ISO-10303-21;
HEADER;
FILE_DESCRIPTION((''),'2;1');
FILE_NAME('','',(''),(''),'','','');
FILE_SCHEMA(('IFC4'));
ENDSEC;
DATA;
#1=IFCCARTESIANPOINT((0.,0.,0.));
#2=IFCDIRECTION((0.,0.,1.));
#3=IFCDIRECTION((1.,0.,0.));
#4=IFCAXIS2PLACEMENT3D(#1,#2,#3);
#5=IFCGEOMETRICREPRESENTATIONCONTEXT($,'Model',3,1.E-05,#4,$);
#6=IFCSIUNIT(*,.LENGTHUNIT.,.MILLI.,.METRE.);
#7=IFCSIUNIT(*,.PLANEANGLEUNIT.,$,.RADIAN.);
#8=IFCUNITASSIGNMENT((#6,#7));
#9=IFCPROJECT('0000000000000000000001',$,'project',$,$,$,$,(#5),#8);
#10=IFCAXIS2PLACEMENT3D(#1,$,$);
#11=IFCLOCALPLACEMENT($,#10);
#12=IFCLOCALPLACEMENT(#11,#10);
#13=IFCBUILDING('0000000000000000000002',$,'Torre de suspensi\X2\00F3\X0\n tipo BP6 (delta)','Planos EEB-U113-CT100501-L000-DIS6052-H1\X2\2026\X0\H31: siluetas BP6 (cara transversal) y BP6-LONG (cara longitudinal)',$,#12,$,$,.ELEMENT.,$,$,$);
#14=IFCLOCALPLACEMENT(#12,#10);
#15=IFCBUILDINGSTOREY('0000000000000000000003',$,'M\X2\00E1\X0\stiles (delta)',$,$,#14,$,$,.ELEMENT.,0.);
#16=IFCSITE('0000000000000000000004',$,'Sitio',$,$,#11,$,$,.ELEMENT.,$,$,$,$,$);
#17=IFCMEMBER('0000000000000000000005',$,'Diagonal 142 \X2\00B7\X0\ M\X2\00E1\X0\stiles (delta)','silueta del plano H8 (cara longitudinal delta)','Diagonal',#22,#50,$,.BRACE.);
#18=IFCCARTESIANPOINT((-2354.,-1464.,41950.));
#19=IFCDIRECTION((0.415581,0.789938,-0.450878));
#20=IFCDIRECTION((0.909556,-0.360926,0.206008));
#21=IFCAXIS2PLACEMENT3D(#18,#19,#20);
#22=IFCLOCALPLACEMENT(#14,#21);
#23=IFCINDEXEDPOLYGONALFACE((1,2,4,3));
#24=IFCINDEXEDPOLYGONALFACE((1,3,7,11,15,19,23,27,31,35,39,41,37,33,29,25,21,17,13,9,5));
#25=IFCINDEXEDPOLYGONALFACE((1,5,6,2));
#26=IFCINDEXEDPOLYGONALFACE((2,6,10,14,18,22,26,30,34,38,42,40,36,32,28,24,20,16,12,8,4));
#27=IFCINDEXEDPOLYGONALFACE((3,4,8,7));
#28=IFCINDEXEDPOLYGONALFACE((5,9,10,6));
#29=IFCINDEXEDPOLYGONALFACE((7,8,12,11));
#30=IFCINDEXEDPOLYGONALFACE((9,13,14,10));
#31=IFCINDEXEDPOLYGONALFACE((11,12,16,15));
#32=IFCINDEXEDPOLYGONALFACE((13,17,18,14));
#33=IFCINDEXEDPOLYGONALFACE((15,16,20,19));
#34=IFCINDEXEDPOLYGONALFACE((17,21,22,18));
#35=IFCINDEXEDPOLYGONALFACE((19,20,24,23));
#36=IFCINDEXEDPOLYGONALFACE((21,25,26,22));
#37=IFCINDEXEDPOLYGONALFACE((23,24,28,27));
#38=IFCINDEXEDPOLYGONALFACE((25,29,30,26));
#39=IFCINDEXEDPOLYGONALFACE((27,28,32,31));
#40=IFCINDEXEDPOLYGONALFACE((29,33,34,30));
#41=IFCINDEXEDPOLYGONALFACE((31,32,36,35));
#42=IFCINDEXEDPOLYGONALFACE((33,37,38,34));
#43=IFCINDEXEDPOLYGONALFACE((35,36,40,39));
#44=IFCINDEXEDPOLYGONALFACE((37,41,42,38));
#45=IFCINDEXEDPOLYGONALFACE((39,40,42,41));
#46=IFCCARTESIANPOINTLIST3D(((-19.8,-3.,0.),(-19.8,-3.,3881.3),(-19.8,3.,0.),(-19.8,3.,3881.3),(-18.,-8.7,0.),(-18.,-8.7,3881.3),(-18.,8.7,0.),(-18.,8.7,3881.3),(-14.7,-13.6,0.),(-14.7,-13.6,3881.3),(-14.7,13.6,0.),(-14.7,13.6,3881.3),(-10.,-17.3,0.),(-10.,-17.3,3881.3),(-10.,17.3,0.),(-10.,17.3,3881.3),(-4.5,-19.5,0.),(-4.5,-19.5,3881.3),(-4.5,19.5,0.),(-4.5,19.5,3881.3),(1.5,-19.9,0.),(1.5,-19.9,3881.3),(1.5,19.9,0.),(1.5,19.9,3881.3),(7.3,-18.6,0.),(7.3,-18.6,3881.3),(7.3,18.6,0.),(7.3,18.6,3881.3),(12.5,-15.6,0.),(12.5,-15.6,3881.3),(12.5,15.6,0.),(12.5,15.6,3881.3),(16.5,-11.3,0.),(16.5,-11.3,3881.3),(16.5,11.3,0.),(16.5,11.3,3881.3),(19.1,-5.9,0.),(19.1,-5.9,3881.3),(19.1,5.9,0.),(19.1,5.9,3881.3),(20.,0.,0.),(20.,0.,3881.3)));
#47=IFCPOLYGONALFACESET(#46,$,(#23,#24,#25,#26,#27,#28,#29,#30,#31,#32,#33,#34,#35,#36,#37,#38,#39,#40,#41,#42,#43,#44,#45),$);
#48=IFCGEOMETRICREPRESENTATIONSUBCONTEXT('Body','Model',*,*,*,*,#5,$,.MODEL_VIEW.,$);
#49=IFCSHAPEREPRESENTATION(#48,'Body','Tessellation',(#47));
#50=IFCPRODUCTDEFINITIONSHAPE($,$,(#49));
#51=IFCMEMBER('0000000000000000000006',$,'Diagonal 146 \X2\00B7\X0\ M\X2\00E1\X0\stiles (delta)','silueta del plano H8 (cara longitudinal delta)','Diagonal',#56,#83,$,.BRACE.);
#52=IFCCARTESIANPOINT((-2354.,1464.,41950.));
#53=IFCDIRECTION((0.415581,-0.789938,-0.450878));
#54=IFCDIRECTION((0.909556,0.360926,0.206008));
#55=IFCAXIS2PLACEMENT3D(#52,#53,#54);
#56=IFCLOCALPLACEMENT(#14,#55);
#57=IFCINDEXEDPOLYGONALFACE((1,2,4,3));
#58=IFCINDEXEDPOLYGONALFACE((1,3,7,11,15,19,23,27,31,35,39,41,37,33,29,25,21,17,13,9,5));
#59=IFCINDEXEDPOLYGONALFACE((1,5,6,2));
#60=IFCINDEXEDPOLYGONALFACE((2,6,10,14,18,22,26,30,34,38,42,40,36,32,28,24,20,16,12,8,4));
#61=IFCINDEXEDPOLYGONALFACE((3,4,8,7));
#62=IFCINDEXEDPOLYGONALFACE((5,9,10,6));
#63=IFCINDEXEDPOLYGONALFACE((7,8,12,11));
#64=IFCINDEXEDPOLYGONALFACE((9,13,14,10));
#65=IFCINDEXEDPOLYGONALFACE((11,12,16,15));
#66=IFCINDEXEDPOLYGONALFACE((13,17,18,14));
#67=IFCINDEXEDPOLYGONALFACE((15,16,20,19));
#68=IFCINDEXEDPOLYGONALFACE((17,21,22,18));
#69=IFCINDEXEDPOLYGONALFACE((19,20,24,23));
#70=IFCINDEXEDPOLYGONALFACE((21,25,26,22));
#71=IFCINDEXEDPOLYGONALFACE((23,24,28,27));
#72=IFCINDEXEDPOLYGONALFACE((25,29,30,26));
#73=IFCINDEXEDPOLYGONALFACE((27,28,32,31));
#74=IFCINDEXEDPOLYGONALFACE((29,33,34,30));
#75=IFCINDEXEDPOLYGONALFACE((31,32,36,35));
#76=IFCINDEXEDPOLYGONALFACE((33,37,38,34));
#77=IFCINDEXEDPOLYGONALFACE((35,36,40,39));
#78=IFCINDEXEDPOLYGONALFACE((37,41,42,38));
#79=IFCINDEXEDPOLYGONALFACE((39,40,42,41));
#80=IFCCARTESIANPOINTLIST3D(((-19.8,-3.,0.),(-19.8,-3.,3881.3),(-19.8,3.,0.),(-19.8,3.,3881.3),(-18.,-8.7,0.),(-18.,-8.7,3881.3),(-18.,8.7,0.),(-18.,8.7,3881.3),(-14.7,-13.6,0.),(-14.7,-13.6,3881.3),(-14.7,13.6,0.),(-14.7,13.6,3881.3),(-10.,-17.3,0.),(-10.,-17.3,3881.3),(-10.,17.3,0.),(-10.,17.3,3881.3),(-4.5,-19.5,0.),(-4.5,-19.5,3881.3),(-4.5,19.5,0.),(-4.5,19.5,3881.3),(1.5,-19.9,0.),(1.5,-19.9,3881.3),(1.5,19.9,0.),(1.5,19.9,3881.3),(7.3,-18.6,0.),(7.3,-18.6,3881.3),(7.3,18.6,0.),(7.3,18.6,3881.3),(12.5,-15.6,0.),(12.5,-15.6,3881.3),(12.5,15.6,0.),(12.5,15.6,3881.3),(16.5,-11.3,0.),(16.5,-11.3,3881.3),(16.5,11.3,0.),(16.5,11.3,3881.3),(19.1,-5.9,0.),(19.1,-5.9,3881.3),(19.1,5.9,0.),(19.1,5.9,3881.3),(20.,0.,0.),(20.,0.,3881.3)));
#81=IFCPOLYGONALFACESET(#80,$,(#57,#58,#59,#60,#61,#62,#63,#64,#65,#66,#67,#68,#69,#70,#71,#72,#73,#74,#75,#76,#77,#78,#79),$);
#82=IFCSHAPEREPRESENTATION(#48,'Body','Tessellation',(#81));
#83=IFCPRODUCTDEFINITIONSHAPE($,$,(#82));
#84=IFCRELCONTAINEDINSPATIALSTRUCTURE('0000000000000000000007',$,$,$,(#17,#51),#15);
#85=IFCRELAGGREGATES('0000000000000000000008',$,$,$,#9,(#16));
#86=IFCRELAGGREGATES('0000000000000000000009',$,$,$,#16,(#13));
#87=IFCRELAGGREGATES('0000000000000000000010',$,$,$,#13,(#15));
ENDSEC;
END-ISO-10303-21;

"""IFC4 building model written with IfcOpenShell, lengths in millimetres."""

from ifc_helpers import new_model, si_unit, frame, origin, origin_with_axes, place, context, subcontext, project, spatial, circle, extrude, element, save


model = new_model("IFC4")

# Units and contexts
model_context = context("Model", 3, precision=1e-05, world=origin_with_axes())
body_context = subcontext(model_context, "Body", "Model", "MODEL_VIEW")
ifc_project = project(units=[si_unit("LENGTHUNIT", "METRE", prefix="MILLI"), si_unit("PLANEANGLEUNIT", "RADIAN")], contexts=[model_context])

# Site, building, storey
site_placement = place(None, origin())
site = spatial("IfcSite", under=ifc_project, at=site_placement, Name="Sitio", CompositionType="ELEMENT")
building_placement = place(site_placement, origin())
building = spatial("IfcBuilding", under=site, at=building_placement, Name="Torre de suspensión tipo BP6 (delta)", Description="Planos EEB-U113-CT100501-L000-DIS6052-H1…H31: siluetas BP6 (cara transversal) y BP6-LONG (cara longitudinal)", CompositionType="ELEMENT")
storey_placement = place(building_placement, origin())
storey = spatial("IfcBuildingStorey", under=building, at=storey_placement, Name="Mástiles (delta)", CompositionType="ELEMENT", Elevation=0.0)

# Members
for number, where, z_axis, x_axis, name in (
    (1, (-2354.0, -1464.0, 41950.0), (0.415581, 0.789938, -0.450878), (0.909556, -0.360926, 0.206008), "Diagonal 142 · Mástiles (delta)"),
    (2, (-2354.0, 1464.0, 41950.0), (0.415581, -0.789938, -0.450878), (0.909556, 0.360926, 0.206008), "Diagonal 146 · Mástiles (delta)"),
):
    element("IfcMember", number, at=place(storey_placement, frame(where, z_axis=z_axis, x_axis=x_axis)), inside=storey, Name=name, Description="silueta del plano H8 (cara longitudinal delta)", ObjectType="Diagonal", PredefinedType="BRACE", context=body_context, shape_type="SweptSolid", body=[
        extrude(circle(Radius=20.0), None, (0.0, 0.0, 1.0), 3881.3),
    ])

save(model, "model.ifc")
